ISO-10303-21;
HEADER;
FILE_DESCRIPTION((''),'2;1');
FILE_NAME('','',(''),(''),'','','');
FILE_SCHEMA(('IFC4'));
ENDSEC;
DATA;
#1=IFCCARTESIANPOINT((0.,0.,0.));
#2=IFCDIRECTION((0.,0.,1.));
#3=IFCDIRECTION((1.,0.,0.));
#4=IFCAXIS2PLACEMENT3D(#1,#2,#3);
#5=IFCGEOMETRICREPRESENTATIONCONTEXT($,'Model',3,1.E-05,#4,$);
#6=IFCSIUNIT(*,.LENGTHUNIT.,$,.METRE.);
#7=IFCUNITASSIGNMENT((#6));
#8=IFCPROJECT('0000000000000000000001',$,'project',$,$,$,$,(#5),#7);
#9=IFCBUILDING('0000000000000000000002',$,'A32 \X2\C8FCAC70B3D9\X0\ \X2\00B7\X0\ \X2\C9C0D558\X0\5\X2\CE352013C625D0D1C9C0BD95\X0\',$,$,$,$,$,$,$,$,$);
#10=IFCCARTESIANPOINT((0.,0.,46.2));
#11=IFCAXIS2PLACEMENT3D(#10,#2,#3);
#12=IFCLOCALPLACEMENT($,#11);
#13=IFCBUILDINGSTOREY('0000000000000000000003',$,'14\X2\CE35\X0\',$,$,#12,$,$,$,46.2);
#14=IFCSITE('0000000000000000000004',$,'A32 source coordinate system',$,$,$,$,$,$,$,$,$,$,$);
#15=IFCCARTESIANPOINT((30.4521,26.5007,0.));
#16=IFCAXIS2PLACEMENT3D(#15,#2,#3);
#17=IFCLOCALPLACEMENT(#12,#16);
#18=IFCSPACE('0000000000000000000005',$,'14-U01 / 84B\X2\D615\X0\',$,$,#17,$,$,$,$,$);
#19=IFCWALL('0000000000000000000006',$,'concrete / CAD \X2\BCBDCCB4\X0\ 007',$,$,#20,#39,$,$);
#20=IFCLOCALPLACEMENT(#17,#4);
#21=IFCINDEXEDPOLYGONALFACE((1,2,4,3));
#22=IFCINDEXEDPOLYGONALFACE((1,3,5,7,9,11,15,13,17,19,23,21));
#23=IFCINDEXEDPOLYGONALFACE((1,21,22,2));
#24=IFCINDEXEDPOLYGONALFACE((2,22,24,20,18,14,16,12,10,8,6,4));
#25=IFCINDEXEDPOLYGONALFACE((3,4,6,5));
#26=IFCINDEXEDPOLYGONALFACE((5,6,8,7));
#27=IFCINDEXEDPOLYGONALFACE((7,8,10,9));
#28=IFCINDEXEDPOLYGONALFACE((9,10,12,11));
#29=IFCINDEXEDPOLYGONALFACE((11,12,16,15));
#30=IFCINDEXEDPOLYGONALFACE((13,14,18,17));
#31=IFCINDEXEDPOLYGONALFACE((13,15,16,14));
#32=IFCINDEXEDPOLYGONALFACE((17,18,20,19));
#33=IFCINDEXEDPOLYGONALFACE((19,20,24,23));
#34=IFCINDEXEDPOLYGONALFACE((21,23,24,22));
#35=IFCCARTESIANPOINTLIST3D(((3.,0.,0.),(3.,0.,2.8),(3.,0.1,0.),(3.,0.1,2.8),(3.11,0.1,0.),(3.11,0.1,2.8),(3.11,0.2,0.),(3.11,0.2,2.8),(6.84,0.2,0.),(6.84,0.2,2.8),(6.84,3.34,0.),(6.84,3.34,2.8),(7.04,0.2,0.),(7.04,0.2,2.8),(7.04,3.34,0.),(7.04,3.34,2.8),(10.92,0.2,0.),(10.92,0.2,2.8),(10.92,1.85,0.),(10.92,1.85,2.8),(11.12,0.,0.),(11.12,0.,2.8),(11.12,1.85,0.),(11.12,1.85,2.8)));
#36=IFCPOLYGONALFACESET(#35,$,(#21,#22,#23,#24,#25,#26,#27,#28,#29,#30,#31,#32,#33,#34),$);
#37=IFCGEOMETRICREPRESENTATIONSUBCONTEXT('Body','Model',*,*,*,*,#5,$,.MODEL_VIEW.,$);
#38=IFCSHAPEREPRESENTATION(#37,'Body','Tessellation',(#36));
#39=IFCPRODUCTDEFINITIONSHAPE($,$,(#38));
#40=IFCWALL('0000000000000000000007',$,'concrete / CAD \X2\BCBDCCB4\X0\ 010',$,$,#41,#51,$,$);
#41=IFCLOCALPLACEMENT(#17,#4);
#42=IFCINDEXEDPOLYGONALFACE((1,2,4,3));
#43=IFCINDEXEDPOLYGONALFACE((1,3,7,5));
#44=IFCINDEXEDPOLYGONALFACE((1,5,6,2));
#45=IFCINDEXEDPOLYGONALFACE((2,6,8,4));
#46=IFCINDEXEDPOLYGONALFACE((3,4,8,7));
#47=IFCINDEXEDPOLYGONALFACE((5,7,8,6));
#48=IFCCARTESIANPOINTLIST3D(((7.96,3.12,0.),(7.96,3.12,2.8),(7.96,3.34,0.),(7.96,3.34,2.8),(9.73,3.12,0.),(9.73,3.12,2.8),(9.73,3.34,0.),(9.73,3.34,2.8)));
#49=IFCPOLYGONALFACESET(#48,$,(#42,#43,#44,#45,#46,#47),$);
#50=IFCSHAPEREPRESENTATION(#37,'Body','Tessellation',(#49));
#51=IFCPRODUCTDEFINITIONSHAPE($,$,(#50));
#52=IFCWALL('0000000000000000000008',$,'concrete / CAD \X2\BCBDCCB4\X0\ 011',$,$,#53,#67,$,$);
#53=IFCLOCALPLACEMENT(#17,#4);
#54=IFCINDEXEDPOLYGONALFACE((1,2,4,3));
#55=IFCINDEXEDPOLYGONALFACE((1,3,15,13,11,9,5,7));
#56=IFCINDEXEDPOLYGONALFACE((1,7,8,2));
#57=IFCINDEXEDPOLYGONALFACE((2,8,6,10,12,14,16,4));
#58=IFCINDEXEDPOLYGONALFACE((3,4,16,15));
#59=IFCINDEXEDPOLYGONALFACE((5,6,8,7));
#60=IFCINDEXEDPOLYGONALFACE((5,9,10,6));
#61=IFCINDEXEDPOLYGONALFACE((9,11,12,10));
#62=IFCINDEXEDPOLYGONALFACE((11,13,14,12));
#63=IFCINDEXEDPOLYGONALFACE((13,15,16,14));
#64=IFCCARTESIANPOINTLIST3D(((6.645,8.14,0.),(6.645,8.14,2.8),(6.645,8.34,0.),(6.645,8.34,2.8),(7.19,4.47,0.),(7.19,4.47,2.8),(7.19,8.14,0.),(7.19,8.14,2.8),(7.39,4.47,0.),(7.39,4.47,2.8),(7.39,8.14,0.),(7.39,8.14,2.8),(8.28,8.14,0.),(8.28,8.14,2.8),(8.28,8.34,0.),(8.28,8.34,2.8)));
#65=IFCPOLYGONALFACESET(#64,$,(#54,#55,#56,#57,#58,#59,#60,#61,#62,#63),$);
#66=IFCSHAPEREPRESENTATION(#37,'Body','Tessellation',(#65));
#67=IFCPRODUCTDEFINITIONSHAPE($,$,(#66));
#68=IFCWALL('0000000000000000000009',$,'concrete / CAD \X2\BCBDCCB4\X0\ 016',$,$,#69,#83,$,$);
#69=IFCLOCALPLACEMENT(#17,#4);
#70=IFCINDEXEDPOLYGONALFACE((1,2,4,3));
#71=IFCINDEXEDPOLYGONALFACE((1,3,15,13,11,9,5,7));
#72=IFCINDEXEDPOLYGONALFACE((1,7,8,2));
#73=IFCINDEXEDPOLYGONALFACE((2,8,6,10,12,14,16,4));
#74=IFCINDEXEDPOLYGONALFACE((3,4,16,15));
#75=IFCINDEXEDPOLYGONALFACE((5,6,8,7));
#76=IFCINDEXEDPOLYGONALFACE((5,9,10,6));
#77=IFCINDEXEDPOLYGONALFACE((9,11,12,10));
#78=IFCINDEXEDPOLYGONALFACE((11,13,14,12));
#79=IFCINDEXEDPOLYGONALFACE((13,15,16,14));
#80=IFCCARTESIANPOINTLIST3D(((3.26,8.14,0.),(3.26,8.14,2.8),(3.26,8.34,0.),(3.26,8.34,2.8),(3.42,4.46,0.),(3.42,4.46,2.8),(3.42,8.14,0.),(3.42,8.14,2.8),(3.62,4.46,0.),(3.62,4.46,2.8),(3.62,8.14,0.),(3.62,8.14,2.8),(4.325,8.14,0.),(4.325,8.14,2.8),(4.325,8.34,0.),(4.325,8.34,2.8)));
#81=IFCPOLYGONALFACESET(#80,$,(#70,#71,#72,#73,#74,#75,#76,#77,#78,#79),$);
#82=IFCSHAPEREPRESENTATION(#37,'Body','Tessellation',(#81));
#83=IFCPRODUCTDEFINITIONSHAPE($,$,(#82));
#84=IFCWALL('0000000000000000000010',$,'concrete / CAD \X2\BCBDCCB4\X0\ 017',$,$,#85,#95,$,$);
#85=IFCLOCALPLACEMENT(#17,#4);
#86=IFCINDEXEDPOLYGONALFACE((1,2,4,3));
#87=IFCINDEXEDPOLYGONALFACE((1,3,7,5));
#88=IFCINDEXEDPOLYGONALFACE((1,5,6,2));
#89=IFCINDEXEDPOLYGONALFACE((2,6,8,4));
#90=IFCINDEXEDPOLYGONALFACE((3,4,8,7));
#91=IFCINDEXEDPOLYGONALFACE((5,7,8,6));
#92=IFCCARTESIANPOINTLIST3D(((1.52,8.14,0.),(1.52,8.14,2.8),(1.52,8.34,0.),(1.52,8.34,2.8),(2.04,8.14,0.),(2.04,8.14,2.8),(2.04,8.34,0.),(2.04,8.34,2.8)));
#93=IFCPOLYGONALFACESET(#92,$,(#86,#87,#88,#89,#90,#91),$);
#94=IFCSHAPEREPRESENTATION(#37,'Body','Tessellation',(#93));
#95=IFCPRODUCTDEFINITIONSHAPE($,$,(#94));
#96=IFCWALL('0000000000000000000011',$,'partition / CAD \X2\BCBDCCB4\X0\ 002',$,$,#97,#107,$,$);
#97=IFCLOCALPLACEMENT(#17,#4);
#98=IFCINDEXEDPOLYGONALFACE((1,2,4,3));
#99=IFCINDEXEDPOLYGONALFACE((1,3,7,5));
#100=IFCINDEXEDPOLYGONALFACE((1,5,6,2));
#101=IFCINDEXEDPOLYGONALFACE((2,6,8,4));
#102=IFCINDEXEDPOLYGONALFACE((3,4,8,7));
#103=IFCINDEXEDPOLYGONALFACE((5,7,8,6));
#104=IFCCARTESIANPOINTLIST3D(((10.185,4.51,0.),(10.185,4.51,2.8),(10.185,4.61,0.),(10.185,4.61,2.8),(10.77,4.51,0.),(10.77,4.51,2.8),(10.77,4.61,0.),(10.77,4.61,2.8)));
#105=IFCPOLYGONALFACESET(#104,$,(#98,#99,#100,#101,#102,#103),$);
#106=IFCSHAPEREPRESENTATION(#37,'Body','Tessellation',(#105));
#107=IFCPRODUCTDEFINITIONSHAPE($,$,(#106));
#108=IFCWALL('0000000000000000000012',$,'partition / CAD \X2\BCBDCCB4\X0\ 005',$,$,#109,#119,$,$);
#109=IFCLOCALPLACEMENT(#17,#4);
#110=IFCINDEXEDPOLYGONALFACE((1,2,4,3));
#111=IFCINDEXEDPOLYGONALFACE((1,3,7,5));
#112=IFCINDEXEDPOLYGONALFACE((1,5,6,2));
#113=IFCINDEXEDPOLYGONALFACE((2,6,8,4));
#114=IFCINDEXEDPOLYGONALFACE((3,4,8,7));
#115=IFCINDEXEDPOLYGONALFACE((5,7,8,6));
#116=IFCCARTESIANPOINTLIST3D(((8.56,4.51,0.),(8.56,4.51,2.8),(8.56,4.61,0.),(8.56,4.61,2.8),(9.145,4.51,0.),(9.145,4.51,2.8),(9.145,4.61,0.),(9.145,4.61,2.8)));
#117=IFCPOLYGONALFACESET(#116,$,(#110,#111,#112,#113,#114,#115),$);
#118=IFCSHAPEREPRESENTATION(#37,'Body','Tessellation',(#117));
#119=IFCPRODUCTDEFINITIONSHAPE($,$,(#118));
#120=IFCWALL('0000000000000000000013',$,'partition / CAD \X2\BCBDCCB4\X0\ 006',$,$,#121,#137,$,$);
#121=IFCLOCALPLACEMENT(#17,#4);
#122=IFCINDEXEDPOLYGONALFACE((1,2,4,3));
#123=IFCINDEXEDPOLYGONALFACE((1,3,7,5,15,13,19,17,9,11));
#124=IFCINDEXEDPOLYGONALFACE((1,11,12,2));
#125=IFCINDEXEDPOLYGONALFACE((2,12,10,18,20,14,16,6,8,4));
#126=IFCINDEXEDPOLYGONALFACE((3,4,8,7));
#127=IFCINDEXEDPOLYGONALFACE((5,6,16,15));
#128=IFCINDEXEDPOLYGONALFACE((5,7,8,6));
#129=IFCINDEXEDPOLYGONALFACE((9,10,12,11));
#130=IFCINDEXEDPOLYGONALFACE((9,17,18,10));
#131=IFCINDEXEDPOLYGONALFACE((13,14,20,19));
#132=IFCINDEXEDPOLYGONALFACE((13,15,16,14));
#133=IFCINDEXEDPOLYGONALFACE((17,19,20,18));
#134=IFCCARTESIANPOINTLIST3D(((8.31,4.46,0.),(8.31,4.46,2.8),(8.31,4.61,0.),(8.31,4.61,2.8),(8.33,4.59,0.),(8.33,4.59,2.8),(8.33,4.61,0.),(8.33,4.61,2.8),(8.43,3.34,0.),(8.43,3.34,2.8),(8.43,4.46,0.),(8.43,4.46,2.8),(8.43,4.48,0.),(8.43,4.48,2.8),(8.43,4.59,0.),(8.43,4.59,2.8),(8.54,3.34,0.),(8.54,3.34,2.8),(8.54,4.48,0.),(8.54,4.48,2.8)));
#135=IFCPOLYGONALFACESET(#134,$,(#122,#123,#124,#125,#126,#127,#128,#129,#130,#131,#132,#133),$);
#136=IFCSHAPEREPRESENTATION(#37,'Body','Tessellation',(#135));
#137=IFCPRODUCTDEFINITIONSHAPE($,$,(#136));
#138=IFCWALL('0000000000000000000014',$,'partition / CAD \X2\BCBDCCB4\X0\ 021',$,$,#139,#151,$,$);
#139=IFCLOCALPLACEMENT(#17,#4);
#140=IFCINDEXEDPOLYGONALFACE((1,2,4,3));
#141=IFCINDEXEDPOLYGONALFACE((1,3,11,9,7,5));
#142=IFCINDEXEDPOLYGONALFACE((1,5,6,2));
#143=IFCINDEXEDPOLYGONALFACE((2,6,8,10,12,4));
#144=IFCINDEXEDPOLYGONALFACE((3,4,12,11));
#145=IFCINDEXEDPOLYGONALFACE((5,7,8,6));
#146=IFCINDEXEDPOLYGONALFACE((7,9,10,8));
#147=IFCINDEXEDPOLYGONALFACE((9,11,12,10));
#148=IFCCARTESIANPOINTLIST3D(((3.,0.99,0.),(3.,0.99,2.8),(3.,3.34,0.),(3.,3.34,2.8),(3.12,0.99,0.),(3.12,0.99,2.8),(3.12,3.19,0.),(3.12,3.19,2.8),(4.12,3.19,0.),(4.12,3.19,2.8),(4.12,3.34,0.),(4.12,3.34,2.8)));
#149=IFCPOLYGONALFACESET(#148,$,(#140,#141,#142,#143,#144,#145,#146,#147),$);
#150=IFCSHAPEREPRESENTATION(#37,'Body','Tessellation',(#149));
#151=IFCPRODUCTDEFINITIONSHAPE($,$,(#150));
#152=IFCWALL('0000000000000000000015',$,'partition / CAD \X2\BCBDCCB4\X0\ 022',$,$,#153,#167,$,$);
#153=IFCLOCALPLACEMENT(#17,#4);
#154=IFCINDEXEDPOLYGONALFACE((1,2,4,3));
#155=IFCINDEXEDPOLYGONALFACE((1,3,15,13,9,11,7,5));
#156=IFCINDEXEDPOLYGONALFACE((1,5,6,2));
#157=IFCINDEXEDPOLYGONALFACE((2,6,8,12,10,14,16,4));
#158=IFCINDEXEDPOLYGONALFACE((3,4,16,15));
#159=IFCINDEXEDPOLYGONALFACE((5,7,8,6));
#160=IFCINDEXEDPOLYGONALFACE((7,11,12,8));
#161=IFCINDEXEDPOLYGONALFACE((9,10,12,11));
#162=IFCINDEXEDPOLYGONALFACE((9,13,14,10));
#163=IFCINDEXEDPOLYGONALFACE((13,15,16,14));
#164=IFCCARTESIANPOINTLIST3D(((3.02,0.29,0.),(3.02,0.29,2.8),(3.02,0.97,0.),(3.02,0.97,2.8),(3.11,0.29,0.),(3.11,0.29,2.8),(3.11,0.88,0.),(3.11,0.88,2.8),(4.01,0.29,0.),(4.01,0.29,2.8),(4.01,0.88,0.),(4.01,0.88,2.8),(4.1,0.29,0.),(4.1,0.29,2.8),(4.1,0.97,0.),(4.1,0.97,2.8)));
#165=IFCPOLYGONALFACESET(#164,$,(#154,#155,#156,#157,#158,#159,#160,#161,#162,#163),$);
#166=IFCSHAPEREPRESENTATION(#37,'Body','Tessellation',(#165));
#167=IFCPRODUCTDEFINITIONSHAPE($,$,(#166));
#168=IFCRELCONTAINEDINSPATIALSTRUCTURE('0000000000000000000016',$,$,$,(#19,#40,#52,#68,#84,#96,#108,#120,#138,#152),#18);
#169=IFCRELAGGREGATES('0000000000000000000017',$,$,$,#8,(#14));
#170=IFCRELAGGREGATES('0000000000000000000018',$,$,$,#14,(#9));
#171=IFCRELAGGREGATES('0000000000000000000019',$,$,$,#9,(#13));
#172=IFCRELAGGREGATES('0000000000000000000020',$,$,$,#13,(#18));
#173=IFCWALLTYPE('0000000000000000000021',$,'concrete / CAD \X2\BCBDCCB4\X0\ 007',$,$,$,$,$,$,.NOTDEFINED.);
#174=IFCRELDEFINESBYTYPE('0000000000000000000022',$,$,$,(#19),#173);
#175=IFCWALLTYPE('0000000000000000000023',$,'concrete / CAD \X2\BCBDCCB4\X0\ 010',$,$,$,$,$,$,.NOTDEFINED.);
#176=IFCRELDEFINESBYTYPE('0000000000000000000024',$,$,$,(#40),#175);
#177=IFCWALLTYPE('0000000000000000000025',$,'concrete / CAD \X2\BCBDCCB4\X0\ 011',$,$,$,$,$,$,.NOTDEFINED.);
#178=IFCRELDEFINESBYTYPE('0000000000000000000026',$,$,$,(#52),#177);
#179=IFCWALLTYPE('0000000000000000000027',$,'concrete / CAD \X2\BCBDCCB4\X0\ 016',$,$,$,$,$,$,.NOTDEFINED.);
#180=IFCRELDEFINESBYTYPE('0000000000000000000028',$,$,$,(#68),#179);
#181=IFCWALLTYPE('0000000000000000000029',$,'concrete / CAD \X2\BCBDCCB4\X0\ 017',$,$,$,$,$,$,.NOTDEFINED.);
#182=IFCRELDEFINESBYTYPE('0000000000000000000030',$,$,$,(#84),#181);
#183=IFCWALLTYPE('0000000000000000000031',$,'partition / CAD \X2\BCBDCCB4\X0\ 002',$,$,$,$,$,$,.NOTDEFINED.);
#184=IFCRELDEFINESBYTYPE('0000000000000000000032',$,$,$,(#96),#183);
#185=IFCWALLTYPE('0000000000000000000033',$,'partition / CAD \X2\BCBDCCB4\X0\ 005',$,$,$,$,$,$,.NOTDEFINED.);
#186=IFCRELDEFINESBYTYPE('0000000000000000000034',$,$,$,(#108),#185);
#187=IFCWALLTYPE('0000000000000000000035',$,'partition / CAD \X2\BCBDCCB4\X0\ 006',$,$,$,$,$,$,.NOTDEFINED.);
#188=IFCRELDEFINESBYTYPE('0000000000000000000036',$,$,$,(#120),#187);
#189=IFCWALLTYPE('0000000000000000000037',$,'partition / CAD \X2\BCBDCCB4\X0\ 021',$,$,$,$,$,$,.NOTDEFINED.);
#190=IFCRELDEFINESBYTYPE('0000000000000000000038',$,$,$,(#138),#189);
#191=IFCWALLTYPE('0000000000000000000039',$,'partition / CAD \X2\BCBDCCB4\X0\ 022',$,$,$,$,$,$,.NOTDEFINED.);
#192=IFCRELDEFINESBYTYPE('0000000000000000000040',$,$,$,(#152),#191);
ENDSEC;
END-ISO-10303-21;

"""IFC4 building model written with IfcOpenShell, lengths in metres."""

from ifc_helpers import new_model, si_unit, frame, origin, origin_with_axes, place, context, subcontext, project, spatial, polyline, outline, extrude, source, transform, mapped, type_object, type_shapes, element, save


model = new_model("IFC4")

# Units and contexts
model_context = context("Model", 3, precision=1e-05, world=origin_with_axes())
body_context = subcontext(model_context, "Body", "Model", "MODEL_VIEW")
ifc_project = project(units=[si_unit("LENGTHUNIT", "METRE")], contexts=[model_context])

# Site, building, storey, space
site = spatial("IfcSite", under=ifc_project, Name="A32 source coordinate system")
building = spatial("IfcBuilding", under=site, Name="A32 주거동 · 지하5층–옥탑지붕")
storey_placement = place(None, frame((0.0, 0.0, 46.2), z_axis=(0.0, 0.0, 1.0), x_axis=(1.0, 0.0, 0.0)))
storey = spatial("IfcBuildingStorey", under=building, at=storey_placement, Name="14층", Elevation=46.2)
space_1_placement = place(storey_placement, frame((30.4521, 26.5007, 0.0), z_axis=(0.0, 0.0, 1.0), x_axis=(1.0, 0.0, 0.0)))
space_1 = spatial("IfcSpace", under=storey, at=space_1_placement, Name="14-U01 / 84B형")

# Walls
wall_type_1 = type_object("IfcWallType", Name="concrete / CAD 벽체 007", PredefinedType="NOTDEFINED")
shared_shape_1 = source(origin(), body_context, "Body", "SweptSolid", [
    extrude(outline(polyline([(3.0, 0.0), (3.0, 0.1), (3.11, 0.1), (3.11, 0.2), (6.84, 0.2), (6.84, 3.34), (7.04, 3.34), (7.04, 0.2), (10.92, 0.2), (10.92, 1.85), (11.12, 1.85), (11.12, 0.0), (3.0, 0.0)])), origin(), (0.0, 0.0, 1.0), 2.8),
])
type_shapes(wall_type_1, [shared_shape_1])
wall_1_placement = place(space_1_placement, origin_with_axes())
element("IfcWall", 1, at=wall_1_placement, inside=space_1, type_object=wall_type_1, Name="concrete / CAD 벽체 007", context=body_context, shape_type="MappedRepresentation", body=[
    mapped(shared_shape_1, transform((0.0, 0.0, 0.0), scale=1.0)),
])
wall_type_2 = type_object("IfcWallType", Name="concrete / CAD 벽체 010", PredefinedType="NOTDEFINED")
shared_shape_2 = source(origin(), body_context, "Body", "SweptSolid", [
    extrude(outline(polyline([(7.96, 3.12), (7.96, 3.34), (9.73, 3.34), (9.73, 3.12), (7.96, 3.12)])), origin(), (0.0, 0.0, 1.0), 2.8),
])
type_shapes(wall_type_2, [shared_shape_2])
wall_2_placement = place(space_1_placement, origin_with_axes())
element("IfcWall", 2, at=wall_2_placement, inside=space_1, type_object=wall_type_2, Name="concrete / CAD 벽체 010", context=body_context, shape_type="MappedRepresentation", body=[
    mapped(shared_shape_2, transform((0.0, 0.0, 0.0), scale=1.0)),
])
wall_type_3 = type_object("IfcWallType", Name="concrete / CAD 벽체 011", PredefinedType="NOTDEFINED")
shared_shape_3 = source(origin(), body_context, "Body", "SweptSolid", [
    extrude(outline(polyline([(7.19, 8.14), (6.645, 8.14), (6.645, 8.34), (8.28, 8.34), (8.28, 8.14), (7.39, 8.14), (7.39, 4.47), (7.19, 4.47), (7.19, 8.14)])), origin(), (0.0, 0.0, 1.0), 2.8),
])
type_shapes(wall_type_3, [shared_shape_3])
wall_3_placement = place(space_1_placement, origin_with_axes())
element("IfcWall", 3, at=wall_3_placement, inside=space_1, type_object=wall_type_3, Name="concrete / CAD 벽체 011", context=body_context, shape_type="MappedRepresentation", body=[
    mapped(shared_shape_3, transform((0.0, 0.0, 0.0), scale=1.0)),
])
wall_type_4 = type_object("IfcWallType", Name="concrete / CAD 벽체 016", PredefinedType="NOTDEFINED")
shared_shape_4 = source(origin(), body_context, "Body", "SweptSolid", [
    extrude(outline(polyline([(3.26, 8.14), (3.26, 8.34), (4.325, 8.34), (4.325, 8.14), (3.62, 8.14), (3.62, 4.46), (3.42, 4.46), (3.42, 8.14), (3.26, 8.14)])), origin(), (0.0, 0.0, 1.0), 2.8),
])
type_shapes(wall_type_4, [shared_shape_4])
wall_4_placement = place(space_1_placement, origin_with_axes())
element("IfcWall", 4, at=wall_4_placement, inside=space_1, type_object=wall_type_4, Name="concrete / CAD 벽체 016", context=body_context, shape_type="MappedRepresentation", body=[
    mapped(shared_shape_4, transform((0.0, 0.0, 0.0), scale=1.0)),
])
wall_type_5 = type_object("IfcWallType", Name="concrete / CAD 벽체 017", PredefinedType="NOTDEFINED")
shared_shape_5 = source(origin(), body_context, "Body", "SweptSolid", [
    extrude(outline(polyline([(1.52, 8.34), (2.04, 8.34), (2.04, 8.14), (1.52, 8.14), (1.52, 8.34)])), origin(), (0.0, 0.0, 1.0), 2.8),
])
type_shapes(wall_type_5, [shared_shape_5])
wall_5_placement = place(space_1_placement, origin_with_axes())
element("IfcWall", 5, at=wall_5_placement, inside=space_1, type_object=wall_type_5, Name="concrete / CAD 벽체 017", context=body_context, shape_type="MappedRepresentation", body=[
    mapped(shared_shape_5, transform((0.0, 0.0, 0.0), scale=1.0)),
])
wall_type_6 = type_object("IfcWallType", Name="partition / CAD 벽체 002", PredefinedType="NOTDEFINED")
shared_shape_6 = source(origin(), body_context, "Body", "SweptSolid", [
    extrude(outline(polyline([(10.185, 4.51), (10.185, 4.61), (10.77, 4.61), (10.77, 4.51), (10.185, 4.51)])), origin(), (0.0, 0.0, 1.0), 2.8),
])
type_shapes(wall_type_6, [shared_shape_6])
wall_6_placement = place(space_1_placement, origin_with_axes())
element("IfcWall", 6, at=wall_6_placement, inside=space_1, type_object=wall_type_6, Name="partition / CAD 벽체 002", context=body_context, shape_type="MappedRepresentation", body=[
    mapped(shared_shape_6, transform((0.0, 0.0, 0.0), scale=1.0)),
])
wall_type_7 = type_object("IfcWallType", Name="partition / CAD 벽체 005", PredefinedType="NOTDEFINED")
shared_shape_7 = source(origin(), body_context, "Body", "SweptSolid", [
    extrude(outline(polyline([(8.56, 4.51), (8.56, 4.61), (9.145, 4.61), (9.145, 4.51), (8.56, 4.51)])), origin(), (0.0, 0.0, 1.0), 2.8),
])
type_shapes(wall_type_7, [shared_shape_7])
wall_7_placement = place(space_1_placement, origin_with_axes())
element("IfcWall", 7, at=wall_7_placement, inside=space_1, type_object=wall_type_7, Name="partition / CAD 벽체 005", context=body_context, shape_type="MappedRepresentation", body=[
    mapped(shared_shape_7, transform((0.0, 0.0, 0.0), scale=1.0)),
])
wall_type_8 = type_object("IfcWallType", Name="partition / CAD 벽체 006", PredefinedType="NOTDEFINED")
shared_shape_8 = source(origin(), body_context, "Body", "SweptSolid", [
    extrude(outline(polyline([(8.43, 4.46), (8.31, 4.46), (8.31, 4.61), (8.33, 4.61), (8.33, 4.59), (8.43, 4.59), (8.43, 4.48), (8.54, 4.48), (8.54, 3.34), (8.43, 3.34), (8.43, 4.46)])), origin(), (0.0, 0.0, 1.0), 2.8),
])
type_shapes(wall_type_8, [shared_shape_8])
wall_8_placement = place(space_1_placement, origin_with_axes())
element("IfcWall", 8, at=wall_8_placement, inside=space_1, type_object=wall_type_8, Name="partition / CAD 벽체 006", context=body_context, shape_type="MappedRepresentation", body=[
    mapped(shared_shape_8, transform((0.0, 0.0, 0.0), scale=1.0)),
])
wall_type_9 = type_object("IfcWallType", Name="partition / CAD 벽체 021", PredefinedType="NOTDEFINED")
shared_shape_9 = source(origin(), body_context, "Body", "SweptSolid", [
    extrude(outline(polyline([(4.12, 3.34), (4.12, 3.19), (3.12, 3.19), (3.12, 0.99), (3.0, 0.99), (3.0, 3.34), (4.12, 3.34)])), origin(), (0.0, 0.0, 1.0), 2.8),
])
type_shapes(wall_type_9, [shared_shape_9])
wall_9_placement = place(space_1_placement, origin_with_axes())
element("IfcWall", 9, at=wall_9_placement, inside=space_1, type_object=wall_type_9, Name="partition / CAD 벽체 021", context=body_context, shape_type="MappedRepresentation", body=[
    mapped(shared_shape_9, transform((0.0, 0.0, 0.0), scale=1.0)),
])
wall_type_10 = type_object("IfcWallType", Name="partition / CAD 벽체 022", PredefinedType="NOTDEFINED")
shared_shape_10 = source(origin(), body_context, "Body", "SweptSolid", [
    extrude(outline(polyline([(4.1, 0.97), (4.1, 0.29), (4.01, 0.29), (4.01, 0.88), (3.11, 0.88), (3.11, 0.29), (3.02, 0.29), (3.02, 0.97), (4.1, 0.97)])), origin(), (0.0, 0.0, 1.0), 2.8),
])
type_shapes(wall_type_10, [shared_shape_10])
wall_10_placement = place(space_1_placement, origin_with_axes())
element("IfcWall", 10, at=wall_10_placement, inside=space_1, type_object=wall_type_10, Name="partition / CAD 벽체 022", context=body_context, shape_type="MappedRepresentation", body=[
    mapped(shared_shape_10, transform((0.0, 0.0, 0.0), scale=1.0)),
])

save(model, "model.ifc")
